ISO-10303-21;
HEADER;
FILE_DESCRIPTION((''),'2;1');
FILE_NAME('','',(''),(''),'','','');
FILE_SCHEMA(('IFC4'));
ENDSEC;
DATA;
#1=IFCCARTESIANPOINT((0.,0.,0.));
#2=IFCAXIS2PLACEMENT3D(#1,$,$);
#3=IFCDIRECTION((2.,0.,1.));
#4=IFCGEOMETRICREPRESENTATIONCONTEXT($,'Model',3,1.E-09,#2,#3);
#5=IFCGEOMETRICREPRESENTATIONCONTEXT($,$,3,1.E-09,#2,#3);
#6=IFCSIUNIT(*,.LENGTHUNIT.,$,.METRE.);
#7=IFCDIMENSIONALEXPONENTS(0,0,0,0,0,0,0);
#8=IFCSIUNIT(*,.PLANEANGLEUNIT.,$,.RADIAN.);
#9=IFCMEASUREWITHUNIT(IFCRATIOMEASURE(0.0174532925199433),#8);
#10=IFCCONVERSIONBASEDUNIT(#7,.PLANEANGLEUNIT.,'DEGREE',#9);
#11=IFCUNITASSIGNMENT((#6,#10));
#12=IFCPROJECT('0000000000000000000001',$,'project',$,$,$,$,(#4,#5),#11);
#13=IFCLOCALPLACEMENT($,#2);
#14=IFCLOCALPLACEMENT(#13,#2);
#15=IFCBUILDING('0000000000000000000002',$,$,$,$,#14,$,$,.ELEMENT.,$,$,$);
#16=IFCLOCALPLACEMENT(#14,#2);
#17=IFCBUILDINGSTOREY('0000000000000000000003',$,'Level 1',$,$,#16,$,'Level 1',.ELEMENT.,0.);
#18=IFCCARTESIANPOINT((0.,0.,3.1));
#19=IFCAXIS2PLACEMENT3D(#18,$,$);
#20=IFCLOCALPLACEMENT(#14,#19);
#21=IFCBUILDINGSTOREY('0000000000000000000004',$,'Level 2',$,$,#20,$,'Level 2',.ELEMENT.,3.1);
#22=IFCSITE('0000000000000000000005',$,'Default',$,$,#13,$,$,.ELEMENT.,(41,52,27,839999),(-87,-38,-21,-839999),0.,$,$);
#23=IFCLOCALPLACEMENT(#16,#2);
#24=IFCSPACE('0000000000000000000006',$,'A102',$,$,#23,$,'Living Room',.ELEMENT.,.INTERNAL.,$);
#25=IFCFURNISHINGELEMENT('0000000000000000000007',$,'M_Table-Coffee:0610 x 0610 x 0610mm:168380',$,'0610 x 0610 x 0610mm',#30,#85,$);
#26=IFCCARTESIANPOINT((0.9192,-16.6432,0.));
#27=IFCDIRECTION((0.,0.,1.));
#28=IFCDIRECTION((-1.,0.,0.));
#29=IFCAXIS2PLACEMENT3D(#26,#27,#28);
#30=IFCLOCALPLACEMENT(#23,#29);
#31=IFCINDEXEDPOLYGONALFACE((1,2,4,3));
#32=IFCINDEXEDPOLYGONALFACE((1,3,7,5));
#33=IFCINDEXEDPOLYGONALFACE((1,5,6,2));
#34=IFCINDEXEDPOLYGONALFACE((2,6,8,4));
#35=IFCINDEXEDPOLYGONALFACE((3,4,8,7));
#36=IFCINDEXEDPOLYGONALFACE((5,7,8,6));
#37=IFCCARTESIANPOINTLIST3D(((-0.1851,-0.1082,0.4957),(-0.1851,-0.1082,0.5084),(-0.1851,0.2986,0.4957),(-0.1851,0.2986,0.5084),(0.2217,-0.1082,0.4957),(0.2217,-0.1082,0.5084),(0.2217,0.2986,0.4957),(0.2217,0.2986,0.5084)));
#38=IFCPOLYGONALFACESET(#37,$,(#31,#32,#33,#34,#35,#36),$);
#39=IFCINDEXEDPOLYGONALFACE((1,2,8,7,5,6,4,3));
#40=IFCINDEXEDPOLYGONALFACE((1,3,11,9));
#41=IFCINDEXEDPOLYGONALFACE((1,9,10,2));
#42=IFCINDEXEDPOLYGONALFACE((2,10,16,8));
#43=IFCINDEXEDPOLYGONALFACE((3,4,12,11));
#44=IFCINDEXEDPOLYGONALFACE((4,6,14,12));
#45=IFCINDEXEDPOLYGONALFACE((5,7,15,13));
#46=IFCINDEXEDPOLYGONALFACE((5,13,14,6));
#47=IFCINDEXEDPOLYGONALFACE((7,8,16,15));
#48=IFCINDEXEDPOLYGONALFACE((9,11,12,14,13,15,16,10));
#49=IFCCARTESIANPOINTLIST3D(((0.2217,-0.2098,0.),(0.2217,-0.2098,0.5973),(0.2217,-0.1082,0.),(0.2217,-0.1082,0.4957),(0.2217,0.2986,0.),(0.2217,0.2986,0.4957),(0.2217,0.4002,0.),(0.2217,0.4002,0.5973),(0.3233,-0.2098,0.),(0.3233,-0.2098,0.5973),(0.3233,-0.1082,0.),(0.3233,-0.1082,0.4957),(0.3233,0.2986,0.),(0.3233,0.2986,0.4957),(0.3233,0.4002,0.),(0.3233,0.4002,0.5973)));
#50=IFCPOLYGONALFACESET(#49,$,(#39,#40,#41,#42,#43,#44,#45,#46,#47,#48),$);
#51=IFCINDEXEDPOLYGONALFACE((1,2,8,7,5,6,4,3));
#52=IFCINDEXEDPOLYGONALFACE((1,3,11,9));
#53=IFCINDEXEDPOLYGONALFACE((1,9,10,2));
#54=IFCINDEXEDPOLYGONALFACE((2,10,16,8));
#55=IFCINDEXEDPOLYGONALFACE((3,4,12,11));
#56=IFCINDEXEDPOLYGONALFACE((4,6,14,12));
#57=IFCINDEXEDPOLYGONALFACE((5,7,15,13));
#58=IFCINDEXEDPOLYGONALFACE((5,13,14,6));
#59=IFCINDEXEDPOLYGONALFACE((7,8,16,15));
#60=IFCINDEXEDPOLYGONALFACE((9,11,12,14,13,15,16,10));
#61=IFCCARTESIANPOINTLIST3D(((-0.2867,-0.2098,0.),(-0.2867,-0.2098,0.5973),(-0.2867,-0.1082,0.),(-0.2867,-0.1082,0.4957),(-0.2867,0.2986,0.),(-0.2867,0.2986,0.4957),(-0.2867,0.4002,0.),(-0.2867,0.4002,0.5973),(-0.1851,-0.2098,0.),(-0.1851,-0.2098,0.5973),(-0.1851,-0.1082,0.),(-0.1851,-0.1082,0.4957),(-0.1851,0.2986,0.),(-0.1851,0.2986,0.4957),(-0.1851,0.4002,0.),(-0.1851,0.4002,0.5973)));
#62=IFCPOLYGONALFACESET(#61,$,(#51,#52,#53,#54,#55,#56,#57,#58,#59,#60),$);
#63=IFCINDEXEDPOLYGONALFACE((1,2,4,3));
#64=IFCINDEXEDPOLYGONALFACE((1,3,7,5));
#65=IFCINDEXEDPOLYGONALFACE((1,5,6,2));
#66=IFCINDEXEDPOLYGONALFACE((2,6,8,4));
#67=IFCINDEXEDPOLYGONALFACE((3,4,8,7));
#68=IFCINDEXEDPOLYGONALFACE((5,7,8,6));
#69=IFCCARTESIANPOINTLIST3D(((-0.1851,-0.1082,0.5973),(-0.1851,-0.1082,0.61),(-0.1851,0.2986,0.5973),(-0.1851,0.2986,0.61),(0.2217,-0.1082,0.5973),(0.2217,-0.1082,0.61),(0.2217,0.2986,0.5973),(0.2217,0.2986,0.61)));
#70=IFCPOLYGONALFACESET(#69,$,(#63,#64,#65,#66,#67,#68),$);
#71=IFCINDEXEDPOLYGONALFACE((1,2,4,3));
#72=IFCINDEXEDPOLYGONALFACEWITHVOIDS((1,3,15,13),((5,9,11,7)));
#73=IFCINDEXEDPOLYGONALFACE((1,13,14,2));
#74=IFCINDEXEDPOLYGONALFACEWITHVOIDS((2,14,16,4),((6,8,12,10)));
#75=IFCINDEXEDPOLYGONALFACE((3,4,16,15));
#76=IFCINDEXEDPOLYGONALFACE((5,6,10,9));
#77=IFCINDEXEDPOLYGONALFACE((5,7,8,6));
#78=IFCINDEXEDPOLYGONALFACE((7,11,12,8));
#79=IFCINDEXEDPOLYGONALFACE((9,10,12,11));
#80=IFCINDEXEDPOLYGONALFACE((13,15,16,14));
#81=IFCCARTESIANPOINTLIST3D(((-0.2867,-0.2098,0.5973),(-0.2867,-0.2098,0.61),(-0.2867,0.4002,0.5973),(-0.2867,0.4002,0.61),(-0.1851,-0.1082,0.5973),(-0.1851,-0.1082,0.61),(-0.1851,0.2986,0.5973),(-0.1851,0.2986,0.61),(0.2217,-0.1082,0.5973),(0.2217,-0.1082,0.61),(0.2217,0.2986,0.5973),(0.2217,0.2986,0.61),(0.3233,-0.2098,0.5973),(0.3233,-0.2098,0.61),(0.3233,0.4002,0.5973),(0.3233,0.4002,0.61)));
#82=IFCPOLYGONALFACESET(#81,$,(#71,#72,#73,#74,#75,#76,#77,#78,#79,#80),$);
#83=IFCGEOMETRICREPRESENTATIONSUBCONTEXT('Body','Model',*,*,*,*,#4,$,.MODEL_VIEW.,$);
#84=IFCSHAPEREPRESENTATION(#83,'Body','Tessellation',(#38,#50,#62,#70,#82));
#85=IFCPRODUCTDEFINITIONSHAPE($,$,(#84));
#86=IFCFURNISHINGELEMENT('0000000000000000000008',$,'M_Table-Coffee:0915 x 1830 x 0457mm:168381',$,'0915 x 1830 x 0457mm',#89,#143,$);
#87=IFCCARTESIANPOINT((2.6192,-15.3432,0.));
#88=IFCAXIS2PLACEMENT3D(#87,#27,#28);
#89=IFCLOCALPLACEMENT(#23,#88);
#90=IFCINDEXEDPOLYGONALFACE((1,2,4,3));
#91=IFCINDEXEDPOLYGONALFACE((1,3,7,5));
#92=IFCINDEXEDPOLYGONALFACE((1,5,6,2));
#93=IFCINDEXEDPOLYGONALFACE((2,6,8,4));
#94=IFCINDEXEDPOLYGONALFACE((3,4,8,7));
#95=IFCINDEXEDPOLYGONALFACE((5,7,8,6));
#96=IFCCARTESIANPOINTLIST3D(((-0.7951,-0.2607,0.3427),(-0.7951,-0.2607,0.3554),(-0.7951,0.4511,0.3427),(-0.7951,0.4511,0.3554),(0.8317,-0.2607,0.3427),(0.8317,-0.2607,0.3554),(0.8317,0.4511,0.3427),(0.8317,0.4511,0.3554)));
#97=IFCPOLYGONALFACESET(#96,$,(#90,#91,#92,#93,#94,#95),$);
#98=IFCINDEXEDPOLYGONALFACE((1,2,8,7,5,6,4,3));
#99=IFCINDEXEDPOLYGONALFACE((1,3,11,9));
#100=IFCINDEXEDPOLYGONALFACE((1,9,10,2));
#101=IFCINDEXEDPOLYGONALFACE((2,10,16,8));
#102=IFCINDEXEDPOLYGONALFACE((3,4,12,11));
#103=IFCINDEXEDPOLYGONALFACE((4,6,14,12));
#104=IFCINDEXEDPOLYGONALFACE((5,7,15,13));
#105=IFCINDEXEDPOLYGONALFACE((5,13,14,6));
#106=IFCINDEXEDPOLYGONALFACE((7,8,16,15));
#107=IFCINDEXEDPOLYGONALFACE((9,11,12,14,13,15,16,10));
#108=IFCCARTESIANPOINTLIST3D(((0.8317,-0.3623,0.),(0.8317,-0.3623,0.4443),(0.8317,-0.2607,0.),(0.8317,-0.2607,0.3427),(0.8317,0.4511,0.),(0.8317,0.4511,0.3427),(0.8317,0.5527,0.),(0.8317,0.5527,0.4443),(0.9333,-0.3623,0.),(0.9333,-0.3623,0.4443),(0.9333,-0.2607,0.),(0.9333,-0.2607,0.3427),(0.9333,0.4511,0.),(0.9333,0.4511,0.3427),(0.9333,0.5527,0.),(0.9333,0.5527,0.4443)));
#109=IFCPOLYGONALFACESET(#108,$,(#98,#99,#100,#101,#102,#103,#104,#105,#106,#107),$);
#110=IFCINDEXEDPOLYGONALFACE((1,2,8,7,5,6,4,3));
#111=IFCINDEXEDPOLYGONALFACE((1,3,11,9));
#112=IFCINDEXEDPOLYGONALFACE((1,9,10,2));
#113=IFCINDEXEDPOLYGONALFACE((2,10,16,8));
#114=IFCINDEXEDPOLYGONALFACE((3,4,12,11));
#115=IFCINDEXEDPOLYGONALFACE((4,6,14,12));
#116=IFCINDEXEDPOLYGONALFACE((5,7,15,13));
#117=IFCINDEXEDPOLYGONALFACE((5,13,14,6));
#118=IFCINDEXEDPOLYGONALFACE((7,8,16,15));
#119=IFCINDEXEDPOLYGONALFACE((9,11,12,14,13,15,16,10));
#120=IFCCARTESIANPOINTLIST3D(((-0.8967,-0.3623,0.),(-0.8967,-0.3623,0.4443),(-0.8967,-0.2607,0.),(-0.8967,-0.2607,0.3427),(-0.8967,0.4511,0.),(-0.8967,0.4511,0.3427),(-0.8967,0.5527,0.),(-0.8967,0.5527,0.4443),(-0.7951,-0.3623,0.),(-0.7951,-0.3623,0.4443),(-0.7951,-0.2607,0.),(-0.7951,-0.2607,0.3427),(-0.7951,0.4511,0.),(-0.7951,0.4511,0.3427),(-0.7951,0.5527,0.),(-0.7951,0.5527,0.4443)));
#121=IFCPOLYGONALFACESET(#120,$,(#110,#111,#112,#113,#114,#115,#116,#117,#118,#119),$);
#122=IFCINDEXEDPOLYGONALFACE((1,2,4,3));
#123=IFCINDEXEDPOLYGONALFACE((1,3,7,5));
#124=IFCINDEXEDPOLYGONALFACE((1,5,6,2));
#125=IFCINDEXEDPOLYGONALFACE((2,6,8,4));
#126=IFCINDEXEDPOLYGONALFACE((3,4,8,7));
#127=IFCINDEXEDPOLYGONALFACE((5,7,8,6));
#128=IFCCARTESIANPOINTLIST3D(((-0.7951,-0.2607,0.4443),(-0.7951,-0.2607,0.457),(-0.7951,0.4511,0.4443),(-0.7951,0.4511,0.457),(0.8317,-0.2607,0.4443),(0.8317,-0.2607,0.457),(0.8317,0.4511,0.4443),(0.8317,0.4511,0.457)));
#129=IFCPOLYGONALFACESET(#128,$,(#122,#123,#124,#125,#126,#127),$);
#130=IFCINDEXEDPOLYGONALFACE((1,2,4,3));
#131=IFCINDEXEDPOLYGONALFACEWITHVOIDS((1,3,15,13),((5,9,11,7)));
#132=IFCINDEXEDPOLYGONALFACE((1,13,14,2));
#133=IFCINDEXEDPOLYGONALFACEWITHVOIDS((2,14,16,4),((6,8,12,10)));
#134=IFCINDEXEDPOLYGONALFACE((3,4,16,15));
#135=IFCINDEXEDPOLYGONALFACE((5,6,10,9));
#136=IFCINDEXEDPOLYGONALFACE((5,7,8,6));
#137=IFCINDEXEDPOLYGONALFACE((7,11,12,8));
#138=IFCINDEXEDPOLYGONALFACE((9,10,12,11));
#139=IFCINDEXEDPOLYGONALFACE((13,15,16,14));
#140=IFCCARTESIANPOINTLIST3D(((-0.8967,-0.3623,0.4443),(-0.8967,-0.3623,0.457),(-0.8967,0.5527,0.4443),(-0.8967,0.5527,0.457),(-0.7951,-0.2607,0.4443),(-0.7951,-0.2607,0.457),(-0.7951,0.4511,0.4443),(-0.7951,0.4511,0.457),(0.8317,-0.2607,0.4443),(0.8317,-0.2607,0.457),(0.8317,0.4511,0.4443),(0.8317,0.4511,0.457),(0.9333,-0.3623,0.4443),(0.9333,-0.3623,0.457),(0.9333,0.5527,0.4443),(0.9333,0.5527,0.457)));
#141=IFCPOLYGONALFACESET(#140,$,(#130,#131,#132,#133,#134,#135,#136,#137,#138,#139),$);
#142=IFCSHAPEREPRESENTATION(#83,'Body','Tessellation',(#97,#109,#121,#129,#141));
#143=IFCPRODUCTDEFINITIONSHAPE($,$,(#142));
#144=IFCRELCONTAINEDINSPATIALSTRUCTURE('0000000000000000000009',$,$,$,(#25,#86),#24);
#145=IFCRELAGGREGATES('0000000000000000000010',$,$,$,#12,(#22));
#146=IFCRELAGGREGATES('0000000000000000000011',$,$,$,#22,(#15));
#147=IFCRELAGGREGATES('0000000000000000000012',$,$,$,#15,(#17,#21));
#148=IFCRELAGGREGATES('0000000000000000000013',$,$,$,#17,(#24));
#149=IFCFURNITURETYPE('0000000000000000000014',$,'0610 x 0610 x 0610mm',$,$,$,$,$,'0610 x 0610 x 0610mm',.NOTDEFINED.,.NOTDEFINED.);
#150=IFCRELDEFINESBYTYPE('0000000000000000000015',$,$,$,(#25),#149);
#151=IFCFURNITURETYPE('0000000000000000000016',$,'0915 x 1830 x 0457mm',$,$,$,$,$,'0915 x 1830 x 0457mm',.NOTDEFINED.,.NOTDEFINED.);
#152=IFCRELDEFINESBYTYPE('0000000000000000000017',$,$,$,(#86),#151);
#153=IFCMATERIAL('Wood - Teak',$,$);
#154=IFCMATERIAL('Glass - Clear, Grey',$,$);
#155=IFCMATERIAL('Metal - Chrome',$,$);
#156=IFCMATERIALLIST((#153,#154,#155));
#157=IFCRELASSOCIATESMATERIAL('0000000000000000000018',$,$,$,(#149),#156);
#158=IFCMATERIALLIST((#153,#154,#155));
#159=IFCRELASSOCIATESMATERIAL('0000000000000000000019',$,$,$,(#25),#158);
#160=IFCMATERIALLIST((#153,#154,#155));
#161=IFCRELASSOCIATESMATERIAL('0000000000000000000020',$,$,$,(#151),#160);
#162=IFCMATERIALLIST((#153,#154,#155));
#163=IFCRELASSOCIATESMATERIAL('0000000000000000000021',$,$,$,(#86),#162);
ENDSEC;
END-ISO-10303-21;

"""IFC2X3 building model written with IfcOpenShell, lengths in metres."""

from ifc_helpers import new_model, entity, si_unit, converted_unit, direction, frame, origin, origin_2d_with_axis, place, context, subcontext, project, spatial, polyline, rectangle, outline, extrude, source, transform, mapped, material, material_list, type_object, type_shapes, element, save


model = new_model("IFC2X3")

# Units and contexts
model_context = context("Model", 3, precision=1e-09, world=origin(), true_north=direction((2.0, 0.0, 1.0)))
context_of_model = context(None, 3, precision=1e-09, world=origin(), true_north=direction((2.0, 0.0, 1.0)))
body_context = subcontext(model_context, "Body", "Model", "MODEL_VIEW")
ifc_project = project(units=[si_unit("LENGTHUNIT", "METRE"), converted_unit("PLANEANGLEUNIT", "DEGREE", entity("IfcRatioMeasure", 0.0174532925199433), si_unit("PLANEANGLEUNIT", "RADIAN"), dimensions=[0, 0, 0, 0, 0, 0, 0])], contexts=[model_context, context_of_model])

# Site, building, storey
site_placement = place(None, origin())
site = spatial("IfcSite", under=ifc_project, at=site_placement, Name="Default", CompositionType="ELEMENT", RefLatitude=(41, 52, 27, 839999), RefLongitude=(-87, -38, -21, -839999), RefElevation=0.0)
building_placement = place(site_placement, origin())
building = spatial("IfcBuilding", under=site, at=building_placement, CompositionType="ELEMENT")
storey_1_placement = place(building_placement, origin())
storey_1 = spatial("IfcBuildingStorey", under=building, at=storey_1_placement, Name="Level 1", LongName="Level 1", CompositionType="ELEMENT", Elevation=0.0)

# Shared definitions
storey_2_placement = place(building_placement, frame((0.0, 0.0, 3.1)))
storey_2 = spatial("IfcBuildingStorey", under=building, at=storey_2_placement, Name="Level 2", LongName="Level 2", CompositionType="ELEMENT", Elevation=3.1)

# Shared definitions
space_1_placement = place(storey_1_placement, origin())
space_1 = spatial("IfcSpace", under=storey_1, at=space_1_placement, Name="A102", LongName="Living Room", CompositionType="ELEMENT", InteriorOrExteriorSpace="INTERNAL")

# Furnishing elements
ifc_material_1 = material(Name="Wood - Teak")
ifc_material_2 = material(Name="Glass - Clear, Grey")
ifc_material_3 = material(Name="Metal - Chrome")
ifc_material_list_1 = material_list([ifc_material_1, ifc_material_2, ifc_material_3])
furniture_type_1 = type_object("IfcFurnitureType", Name="0610 x 0610 x 0610mm", ElementType="0610 x 0610 x 0610mm", AssemblyPlace="NOTDEFINED", material=ifc_material_list_1)
shared_shape_1 = source(origin(), body_context, "Body", "SweptSolid", [
    extrude(rectangle(XDim=0.4068, YDim=0.4068, at=origin_2d_with_axis()), frame((0.0183, 0.0952, 0.4957), z_axis=(0.0, 0.0, 1.0), x_axis=(-1.0, 0.0, 0.0)), (0.0, 0.0, 1.0), 0.0127),
    extrude(outline(polyline([(-0.2732, -0.305), (0.324, -0.305), (0.324, 0.305), (-0.2732, 0.305), (-0.2732, 0.2034), (0.2225, 0.2034), (0.2225, -0.2034), (-0.2732, -0.2034), (-0.2732, -0.305)])), frame((0.2217, 0.0952, 0.2732), z_axis=(1.0, 0.0, 0.0), x_axis=(0.0, 0.0, 1.0)), (0.0, 0.0, 1.0), 0.1016),
    extrude(outline(polyline([(-0.305, -0.3241), (0.305, -0.3241), (0.305, 0.2733), (0.2034, 0.2733), (0.2034, -0.2224), (-0.2034, -0.2224), (-0.2034, 0.2733), (-0.305, 0.2733), (-0.305, -0.3241)])), frame((-0.2867, 0.0952, 0.2733), z_axis=(1.0, 0.0, 0.0), x_axis=(0.0, -1.0, 0.0)), (0.0, 0.0, 1.0), 0.1016),
    extrude(rectangle(XDim=0.4068, YDim=0.4068, at=origin_2d_with_axis()), frame((0.0183, 0.0952, 0.5973), z_axis=(0.0, 0.0, 1.0), x_axis=(-1.0, 0.0, 0.0)), (0.0, 0.0, 1.0), 0.0127),
    extrude(outline(polyline([(-0.305, -0.305), (0.305, -0.305), (0.305, 0.305), (-0.305, 0.305), (-0.305, -0.305)]), holes=[polyline([(-0.2034, -0.2034), (-0.2034, 0.2034), (0.2034, 0.2034), (0.2034, -0.2034), (-0.2034, -0.2034)])]), frame((0.0183, 0.0952, 0.5973), z_axis=(0.0, 0.0, 1.0), x_axis=(-1.0, 0.0, 0.0)), (0.0, 0.0, 1.0), 0.0127),
])
type_shapes(furniture_type_1, [shared_shape_1])
ifc_material_list_2 = material_list([ifc_material_1, ifc_material_2, ifc_material_3])
furnishing_1_placement = place(space_1_placement, frame((0.9192, -16.6432, 0.0), z_axis=(0.0, 0.0, 1.0), x_axis=(-1.0, 0.0, 0.0)))
element("IfcFurnishingElement", 1, at=furnishing_1_placement, inside=space_1, type_object=furniture_type_1, material=ifc_material_list_2, Name="M_Table-Coffee:0610 x 0610 x 0610mm:168380", ObjectType="0610 x 0610 x 0610mm", context=body_context, shape_type="MappedRepresentation", body=[
    mapped(shared_shape_1, transform((0.0, 0.0, 0.0), scale=1.0)),
])
ifc_material_list_3 = material_list([ifc_material_1, ifc_material_2, ifc_material_3])
ifc_material_list_4 = material_list([ifc_material_1, ifc_material_2, ifc_material_3])
furniture_type_2 = type_object("IfcFurnitureType", Name="0915 x 1830 x 0457mm", ElementType="0915 x 1830 x 0457mm", AssemblyPlace="NOTDEFINED", material=ifc_material_list_4)
shared_shape_2 = source(origin(), body_context, "Body", "SweptSolid", [
    extrude(rectangle(XDim=1.6268, YDim=0.7118, at=origin_2d_with_axis()), frame((0.0183, 0.0952, 0.3427), z_axis=(0.0, 0.0, 1.0), x_axis=(-1.0, 0.0, 0.0)), (0.0, 0.0, 1.0), 0.0127),
    extrude(outline(polyline([(-0.1967, -0.4575), (0.2475, -0.4575), (0.2475, 0.4575), (-0.1967, 0.4575), (-0.1967, 0.3559), (0.146, 0.3559), (0.146, -0.3559), (-0.1967, -0.3559), (-0.1967, -0.4575)])), frame((0.8317, 0.0952, 0.1967), z_axis=(1.0, 0.0, 0.0), x_axis=(0.0, 0.0, 1.0)), (0.0, 0.0, 1.0), 0.1016),
    extrude(outline(polyline([(-0.4575, -0.2476), (0.4575, -0.2476), (0.4575, 0.1968), (0.3559, 0.1968), (0.3559, -0.1459), (-0.3559, -0.1459), (-0.3559, 0.1968), (-0.4575, 0.1968), (-0.4575, -0.2476)])), frame((-0.8967, 0.0952, 0.1968), z_axis=(1.0, 0.0, 0.0), x_axis=(0.0, -1.0, 0.0)), (0.0, 0.0, 1.0), 0.1016),
    extrude(rectangle(XDim=1.6268, YDim=0.7118, at=origin_2d_with_axis()), frame((0.0183, 0.0952, 0.4443), z_axis=(0.0, 0.0, 1.0), x_axis=(-1.0, 0.0, 0.0)), (0.0, 0.0, 1.0), 0.0127),
    extrude(outline(polyline([(-0.915, -0.4575), (0.915, -0.4575), (0.915, 0.4575), (-0.915, 0.4575), (-0.915, -0.4575)]), holes=[polyline([(-0.8134, -0.3559), (-0.8134, 0.3559), (0.8134, 0.3559), (0.8134, -0.3559), (-0.8134, -0.3559)])]), frame((0.0183, 0.0952, 0.4443), z_axis=(0.0, 0.0, 1.0), x_axis=(-1.0, 0.0, 0.0)), (0.0, 0.0, 1.0), 0.0127),
])
type_shapes(furniture_type_2, [shared_shape_2])
furnishing_2_placement = place(space_1_placement, frame((2.6192, -15.3432, 0.0), z_axis=(0.0, 0.0, 1.0), x_axis=(-1.0, 0.0, 0.0)))
element("IfcFurnishingElement", 2, at=furnishing_2_placement, inside=space_1, type_object=furniture_type_2, material=ifc_material_list_3, Name="M_Table-Coffee:0915 x 1830 x 0457mm:168381", ObjectType="0915 x 1830 x 0457mm", context=body_context, shape_type="MappedRepresentation", body=[
    mapped(shared_shape_2, transform((0.0, 0.0, 0.0), scale=1.0)),
])

save(model, "model.ifc")
